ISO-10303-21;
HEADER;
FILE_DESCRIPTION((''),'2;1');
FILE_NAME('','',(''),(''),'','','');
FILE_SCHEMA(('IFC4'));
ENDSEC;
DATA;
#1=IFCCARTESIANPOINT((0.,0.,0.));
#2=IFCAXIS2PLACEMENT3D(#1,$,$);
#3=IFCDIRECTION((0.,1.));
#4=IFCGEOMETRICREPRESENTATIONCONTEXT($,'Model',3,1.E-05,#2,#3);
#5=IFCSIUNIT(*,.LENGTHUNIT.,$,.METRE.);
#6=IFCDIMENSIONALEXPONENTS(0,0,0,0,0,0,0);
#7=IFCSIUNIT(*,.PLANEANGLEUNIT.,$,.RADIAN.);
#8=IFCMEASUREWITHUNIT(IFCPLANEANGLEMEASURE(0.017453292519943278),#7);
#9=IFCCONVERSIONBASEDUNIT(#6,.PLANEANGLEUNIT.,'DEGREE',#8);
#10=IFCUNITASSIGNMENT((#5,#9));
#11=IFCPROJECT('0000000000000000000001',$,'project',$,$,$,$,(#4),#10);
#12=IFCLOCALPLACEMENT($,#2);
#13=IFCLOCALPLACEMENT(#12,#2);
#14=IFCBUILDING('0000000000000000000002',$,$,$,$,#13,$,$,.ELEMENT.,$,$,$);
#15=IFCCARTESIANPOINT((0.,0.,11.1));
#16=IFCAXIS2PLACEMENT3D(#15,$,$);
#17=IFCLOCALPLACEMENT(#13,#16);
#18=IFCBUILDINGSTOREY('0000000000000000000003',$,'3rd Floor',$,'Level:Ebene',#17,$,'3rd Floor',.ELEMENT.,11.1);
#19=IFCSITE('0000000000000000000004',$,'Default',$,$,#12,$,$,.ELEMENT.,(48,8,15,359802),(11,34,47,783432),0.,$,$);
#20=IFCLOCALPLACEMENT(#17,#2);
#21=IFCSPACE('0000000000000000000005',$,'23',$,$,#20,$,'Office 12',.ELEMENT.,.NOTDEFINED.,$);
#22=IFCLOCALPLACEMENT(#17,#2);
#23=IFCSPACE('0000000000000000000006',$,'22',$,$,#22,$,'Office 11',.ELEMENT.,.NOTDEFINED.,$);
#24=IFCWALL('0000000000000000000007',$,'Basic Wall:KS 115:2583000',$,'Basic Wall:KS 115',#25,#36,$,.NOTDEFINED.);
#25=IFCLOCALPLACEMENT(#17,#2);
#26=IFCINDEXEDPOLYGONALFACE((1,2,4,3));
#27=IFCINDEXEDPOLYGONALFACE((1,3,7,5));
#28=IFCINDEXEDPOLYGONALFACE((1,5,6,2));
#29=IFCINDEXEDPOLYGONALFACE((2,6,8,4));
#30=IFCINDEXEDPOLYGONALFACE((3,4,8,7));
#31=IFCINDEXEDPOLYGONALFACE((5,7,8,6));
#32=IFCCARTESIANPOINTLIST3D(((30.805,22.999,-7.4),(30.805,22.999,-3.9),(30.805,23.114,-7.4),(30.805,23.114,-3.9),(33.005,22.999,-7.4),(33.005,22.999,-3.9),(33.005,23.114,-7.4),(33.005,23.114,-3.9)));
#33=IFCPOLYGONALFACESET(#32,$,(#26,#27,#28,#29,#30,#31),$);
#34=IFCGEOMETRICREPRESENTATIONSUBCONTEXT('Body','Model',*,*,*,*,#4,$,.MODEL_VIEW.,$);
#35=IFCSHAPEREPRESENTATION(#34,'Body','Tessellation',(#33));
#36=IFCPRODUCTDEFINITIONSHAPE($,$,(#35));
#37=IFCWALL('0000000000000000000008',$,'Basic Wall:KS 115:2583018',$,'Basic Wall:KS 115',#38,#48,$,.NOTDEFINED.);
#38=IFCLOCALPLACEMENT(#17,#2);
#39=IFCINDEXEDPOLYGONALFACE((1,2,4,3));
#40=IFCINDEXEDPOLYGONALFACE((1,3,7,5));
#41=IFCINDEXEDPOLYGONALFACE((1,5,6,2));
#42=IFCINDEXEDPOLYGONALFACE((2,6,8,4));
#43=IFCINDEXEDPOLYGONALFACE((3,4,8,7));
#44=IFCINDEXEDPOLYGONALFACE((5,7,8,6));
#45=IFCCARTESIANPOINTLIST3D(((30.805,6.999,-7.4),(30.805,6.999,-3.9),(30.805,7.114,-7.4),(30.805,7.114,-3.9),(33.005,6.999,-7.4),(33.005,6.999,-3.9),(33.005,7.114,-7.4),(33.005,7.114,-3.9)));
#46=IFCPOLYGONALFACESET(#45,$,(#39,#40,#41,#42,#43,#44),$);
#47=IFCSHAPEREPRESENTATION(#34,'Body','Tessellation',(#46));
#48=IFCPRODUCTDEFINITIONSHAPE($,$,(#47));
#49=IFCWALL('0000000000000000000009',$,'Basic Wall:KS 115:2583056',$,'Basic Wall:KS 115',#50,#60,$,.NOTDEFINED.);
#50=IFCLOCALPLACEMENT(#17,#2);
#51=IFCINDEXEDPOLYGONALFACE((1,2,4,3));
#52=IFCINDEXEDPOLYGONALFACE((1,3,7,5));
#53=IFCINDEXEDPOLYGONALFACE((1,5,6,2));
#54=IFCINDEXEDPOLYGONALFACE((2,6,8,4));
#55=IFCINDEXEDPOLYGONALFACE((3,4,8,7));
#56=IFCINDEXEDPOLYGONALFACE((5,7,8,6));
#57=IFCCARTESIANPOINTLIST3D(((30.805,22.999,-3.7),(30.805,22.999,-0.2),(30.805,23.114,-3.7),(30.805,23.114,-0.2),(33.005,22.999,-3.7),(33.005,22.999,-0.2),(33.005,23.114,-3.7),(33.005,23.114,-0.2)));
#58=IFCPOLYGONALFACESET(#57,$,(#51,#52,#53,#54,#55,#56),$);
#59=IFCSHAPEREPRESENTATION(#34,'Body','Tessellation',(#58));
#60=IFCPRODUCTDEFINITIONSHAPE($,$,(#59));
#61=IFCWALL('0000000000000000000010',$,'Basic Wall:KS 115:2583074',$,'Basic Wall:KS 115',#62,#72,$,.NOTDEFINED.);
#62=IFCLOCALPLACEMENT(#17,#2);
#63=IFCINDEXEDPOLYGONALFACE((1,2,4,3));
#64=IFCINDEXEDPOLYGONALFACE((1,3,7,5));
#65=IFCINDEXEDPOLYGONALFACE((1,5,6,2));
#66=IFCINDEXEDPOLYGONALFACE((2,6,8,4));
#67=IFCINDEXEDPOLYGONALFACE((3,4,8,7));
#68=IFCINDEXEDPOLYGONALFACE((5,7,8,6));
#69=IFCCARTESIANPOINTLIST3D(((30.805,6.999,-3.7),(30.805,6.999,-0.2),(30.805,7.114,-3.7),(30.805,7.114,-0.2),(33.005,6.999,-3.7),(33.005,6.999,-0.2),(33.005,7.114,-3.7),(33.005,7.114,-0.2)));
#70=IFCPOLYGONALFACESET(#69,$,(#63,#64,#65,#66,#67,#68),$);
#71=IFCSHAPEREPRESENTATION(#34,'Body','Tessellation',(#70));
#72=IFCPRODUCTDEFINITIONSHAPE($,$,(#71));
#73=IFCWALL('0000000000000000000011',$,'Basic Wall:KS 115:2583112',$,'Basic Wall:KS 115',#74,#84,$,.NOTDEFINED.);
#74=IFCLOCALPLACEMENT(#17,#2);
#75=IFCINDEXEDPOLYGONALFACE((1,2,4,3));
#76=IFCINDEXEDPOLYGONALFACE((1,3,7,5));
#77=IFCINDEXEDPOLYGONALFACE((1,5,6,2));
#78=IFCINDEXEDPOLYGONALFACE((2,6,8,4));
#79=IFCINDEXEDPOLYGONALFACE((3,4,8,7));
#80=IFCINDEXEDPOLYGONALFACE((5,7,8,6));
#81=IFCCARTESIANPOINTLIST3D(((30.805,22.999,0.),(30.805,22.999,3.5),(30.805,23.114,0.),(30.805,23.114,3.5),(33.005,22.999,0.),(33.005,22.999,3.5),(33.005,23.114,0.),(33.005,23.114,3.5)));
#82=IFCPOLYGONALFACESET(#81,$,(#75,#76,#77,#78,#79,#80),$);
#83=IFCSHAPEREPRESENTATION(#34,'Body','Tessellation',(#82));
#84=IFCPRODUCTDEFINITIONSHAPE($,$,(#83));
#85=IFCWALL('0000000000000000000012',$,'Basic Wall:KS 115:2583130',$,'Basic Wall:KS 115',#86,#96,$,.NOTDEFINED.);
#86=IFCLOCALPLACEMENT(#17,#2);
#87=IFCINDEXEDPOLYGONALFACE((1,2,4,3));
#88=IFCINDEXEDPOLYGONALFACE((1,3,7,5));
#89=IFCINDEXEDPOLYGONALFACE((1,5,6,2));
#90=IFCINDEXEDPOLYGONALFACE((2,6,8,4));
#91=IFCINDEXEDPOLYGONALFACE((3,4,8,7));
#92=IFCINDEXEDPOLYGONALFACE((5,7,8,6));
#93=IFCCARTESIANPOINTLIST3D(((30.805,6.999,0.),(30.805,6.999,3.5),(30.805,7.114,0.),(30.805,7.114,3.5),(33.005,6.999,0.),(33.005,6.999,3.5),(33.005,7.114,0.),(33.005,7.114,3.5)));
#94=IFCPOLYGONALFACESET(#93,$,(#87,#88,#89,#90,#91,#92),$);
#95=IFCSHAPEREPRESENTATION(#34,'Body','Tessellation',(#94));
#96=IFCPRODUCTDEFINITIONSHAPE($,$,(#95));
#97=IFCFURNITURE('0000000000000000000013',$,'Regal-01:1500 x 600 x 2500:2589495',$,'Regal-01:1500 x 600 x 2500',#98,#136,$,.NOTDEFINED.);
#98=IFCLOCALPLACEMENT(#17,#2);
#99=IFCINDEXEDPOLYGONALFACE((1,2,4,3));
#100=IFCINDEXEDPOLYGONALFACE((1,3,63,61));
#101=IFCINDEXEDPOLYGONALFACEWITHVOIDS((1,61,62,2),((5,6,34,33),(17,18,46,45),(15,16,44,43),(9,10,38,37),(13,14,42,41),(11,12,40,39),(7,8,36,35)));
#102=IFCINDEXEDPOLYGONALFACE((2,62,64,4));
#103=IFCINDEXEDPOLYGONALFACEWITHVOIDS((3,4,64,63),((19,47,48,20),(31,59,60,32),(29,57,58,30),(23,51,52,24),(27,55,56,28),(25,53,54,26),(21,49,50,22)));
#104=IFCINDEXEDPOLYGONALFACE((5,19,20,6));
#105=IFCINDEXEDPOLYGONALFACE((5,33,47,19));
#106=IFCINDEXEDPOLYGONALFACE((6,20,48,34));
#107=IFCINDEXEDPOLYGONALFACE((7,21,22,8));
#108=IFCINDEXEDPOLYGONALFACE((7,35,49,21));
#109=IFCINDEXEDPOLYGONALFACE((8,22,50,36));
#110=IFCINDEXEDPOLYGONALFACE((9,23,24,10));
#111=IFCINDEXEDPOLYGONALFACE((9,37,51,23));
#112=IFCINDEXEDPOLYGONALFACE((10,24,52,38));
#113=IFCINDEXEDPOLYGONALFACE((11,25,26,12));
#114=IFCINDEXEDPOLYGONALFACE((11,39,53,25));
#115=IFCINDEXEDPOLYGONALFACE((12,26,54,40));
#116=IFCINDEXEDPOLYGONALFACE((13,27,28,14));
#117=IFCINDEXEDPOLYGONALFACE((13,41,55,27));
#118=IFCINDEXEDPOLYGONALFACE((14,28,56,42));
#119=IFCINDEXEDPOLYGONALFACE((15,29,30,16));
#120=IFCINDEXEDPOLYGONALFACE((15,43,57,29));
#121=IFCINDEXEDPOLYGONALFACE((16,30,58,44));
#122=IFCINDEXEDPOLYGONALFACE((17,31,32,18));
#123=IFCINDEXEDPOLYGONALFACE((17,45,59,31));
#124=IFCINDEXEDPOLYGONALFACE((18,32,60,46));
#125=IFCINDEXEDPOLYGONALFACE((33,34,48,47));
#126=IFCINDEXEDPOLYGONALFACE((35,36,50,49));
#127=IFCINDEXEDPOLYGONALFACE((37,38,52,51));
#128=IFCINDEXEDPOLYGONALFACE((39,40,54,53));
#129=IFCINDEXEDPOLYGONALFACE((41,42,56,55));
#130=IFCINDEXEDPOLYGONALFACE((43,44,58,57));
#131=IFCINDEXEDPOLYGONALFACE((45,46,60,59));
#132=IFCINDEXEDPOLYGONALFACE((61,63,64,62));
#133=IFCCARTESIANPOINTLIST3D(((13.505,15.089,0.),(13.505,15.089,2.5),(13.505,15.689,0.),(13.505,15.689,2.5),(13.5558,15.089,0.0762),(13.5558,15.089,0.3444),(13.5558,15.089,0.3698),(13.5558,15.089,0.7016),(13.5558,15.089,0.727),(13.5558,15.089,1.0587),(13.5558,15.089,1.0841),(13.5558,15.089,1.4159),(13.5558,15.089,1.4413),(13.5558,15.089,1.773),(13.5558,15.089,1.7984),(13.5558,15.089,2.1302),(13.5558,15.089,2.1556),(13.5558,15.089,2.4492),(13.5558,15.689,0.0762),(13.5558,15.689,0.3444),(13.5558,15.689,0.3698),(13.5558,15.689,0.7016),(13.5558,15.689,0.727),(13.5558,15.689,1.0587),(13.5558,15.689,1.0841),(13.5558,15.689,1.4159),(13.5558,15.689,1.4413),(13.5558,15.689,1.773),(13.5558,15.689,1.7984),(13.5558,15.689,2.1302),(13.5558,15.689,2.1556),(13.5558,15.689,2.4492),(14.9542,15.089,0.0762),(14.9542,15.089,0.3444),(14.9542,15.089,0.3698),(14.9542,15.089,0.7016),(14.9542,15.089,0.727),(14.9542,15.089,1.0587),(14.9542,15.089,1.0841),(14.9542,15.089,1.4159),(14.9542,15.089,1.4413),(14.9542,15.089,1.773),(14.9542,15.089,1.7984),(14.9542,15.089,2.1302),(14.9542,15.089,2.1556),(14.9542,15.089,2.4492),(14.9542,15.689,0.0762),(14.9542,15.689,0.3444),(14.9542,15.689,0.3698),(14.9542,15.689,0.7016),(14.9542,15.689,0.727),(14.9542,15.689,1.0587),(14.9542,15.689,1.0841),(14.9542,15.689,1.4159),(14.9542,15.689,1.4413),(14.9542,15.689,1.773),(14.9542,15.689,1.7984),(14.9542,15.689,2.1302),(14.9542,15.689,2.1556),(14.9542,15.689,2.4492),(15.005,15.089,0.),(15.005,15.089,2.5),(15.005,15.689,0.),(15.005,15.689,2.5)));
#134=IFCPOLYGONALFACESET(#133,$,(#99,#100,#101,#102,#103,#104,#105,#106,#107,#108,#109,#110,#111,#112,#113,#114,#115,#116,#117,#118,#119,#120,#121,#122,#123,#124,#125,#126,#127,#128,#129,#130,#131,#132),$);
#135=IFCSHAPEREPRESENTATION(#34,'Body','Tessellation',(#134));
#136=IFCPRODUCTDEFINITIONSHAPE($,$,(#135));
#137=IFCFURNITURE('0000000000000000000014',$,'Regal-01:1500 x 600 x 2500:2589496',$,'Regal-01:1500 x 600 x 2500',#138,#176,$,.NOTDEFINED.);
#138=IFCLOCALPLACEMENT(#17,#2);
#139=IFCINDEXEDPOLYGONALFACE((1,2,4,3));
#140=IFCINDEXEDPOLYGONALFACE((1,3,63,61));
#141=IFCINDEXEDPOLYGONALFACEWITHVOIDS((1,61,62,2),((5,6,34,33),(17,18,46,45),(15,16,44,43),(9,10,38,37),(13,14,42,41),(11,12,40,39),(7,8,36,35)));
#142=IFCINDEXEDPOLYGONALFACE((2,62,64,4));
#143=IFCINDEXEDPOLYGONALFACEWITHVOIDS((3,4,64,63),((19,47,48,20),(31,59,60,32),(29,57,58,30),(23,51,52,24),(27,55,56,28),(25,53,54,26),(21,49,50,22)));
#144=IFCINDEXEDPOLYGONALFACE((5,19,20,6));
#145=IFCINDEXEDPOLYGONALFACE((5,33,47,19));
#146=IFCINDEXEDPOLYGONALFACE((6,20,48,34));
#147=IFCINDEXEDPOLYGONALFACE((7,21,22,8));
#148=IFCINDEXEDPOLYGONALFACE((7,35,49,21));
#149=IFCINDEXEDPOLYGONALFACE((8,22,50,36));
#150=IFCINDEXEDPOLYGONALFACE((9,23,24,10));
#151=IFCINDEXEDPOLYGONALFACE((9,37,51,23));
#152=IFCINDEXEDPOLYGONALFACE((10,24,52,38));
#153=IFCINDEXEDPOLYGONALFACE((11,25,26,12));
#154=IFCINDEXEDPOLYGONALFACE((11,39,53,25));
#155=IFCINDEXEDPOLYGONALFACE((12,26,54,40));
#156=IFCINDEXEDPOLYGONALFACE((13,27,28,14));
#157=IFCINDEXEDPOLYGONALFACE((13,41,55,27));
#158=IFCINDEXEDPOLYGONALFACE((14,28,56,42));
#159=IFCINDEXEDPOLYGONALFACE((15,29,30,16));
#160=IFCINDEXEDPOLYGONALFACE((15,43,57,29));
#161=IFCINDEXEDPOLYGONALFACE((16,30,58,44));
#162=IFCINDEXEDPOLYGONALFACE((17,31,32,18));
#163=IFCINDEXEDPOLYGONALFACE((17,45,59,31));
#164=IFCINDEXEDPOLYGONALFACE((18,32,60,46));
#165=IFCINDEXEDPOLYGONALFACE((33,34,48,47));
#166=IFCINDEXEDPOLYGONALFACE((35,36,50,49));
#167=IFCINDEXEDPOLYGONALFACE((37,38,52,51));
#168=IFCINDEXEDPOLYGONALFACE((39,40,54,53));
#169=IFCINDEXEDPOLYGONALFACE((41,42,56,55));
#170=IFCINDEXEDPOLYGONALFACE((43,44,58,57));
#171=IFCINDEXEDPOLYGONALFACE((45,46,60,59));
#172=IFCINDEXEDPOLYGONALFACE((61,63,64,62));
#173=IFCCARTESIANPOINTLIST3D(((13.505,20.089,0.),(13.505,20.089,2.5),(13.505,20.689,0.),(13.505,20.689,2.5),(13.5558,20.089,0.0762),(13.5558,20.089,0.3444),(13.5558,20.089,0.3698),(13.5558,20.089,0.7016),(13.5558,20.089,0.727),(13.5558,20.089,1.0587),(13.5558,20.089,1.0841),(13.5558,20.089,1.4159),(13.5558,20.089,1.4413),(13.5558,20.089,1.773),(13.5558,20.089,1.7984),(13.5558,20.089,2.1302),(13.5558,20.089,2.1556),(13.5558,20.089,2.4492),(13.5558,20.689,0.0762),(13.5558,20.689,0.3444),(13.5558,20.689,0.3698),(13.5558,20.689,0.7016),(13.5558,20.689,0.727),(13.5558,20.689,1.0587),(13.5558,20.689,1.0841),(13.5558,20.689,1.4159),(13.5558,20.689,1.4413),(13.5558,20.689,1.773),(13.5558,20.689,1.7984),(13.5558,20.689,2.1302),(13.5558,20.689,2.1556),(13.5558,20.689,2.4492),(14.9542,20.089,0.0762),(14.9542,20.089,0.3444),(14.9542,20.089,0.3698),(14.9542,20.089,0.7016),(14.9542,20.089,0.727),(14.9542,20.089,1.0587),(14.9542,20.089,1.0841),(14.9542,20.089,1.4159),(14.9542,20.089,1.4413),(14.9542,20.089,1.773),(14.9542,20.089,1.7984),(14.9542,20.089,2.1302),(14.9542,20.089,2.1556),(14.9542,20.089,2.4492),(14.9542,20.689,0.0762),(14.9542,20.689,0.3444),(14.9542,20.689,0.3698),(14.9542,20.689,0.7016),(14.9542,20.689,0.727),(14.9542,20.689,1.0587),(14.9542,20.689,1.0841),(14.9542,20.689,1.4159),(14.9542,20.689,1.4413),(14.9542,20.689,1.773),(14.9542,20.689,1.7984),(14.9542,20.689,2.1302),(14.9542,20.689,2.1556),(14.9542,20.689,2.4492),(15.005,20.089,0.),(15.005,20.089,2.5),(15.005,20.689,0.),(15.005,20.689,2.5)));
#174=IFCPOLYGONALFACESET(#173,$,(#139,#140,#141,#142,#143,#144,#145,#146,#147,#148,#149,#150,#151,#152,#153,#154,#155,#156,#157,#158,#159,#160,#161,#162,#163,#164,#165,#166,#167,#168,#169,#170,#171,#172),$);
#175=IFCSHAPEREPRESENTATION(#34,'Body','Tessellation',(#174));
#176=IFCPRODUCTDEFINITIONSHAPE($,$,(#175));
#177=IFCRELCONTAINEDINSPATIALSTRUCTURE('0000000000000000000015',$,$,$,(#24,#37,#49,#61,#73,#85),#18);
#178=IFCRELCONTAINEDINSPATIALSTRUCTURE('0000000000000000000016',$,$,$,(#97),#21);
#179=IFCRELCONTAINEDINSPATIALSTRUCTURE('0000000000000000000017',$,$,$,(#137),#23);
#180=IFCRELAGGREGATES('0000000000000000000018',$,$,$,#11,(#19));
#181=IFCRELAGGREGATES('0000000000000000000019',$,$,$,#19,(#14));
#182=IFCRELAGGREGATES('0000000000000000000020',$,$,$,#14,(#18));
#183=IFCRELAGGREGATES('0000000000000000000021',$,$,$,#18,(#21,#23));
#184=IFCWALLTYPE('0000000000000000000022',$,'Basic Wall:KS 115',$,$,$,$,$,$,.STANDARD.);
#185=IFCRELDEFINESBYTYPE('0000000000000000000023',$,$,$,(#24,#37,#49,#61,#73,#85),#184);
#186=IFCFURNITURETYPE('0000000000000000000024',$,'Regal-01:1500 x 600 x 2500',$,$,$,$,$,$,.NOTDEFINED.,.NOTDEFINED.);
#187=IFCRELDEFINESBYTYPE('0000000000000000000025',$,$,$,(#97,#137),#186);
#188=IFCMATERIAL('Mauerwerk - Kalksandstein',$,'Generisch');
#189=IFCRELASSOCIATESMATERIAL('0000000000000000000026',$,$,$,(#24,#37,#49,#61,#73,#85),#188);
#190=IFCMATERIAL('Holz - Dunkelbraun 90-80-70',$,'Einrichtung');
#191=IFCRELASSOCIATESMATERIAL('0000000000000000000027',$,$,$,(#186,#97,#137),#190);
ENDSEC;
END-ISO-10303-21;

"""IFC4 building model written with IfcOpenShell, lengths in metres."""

from ifc_helpers import new_model, entity, si_unit, converted_unit, direction, frame, origin, place, context, subcontext, project, spatial, indexed_curve, outline, extrude, source, transform, mapped, material, type_object, type_shapes, element, save


model = new_model("IFC4")

# Units and contexts
model_context = context("Model", 3, precision=1e-05, world=origin(), true_north=direction((0.0, 1.0)))
body_context = subcontext(model_context, "Body", "Model", "MODEL_VIEW")
ifc_project = project(units=[si_unit("LENGTHUNIT", "METRE"), converted_unit("PLANEANGLEUNIT", "DEGREE", entity("IfcPlaneAngleMeasure", 0.017453292519943278), si_unit("PLANEANGLEUNIT", "RADIAN"), dimensions=[0, 0, 0, 0, 0, 0, 0])], contexts=[model_context])

# Site, building, storey
site_placement = place(None, origin())
site = spatial("IfcSite", under=ifc_project, at=site_placement, Name="Default", CompositionType="ELEMENT", RefLatitude=(48, 8, 15, 359802), RefLongitude=(11, 34, 47, 783432), RefElevation=0.0)
building_placement = place(site_placement, origin())
building = spatial("IfcBuilding", under=site, at=building_placement, CompositionType="ELEMENT")
storey_placement = place(building_placement, frame((0.0, 0.0, 11.1)))
storey = spatial("IfcBuildingStorey", under=building, at=storey_placement, Name="3rd Floor", ObjectType="Level:Ebene", LongName="3rd Floor", CompositionType="ELEMENT", Elevation=11.1)

# Walls
ifc_material_1 = material(Name="Mauerwerk - Kalksandstein", Category="Generisch")
wall_type_1 = type_object("IfcWallType", Name="Basic Wall:KS 115", PredefinedType="STANDARD")
wall_1_placement = place(storey_placement, frame((30.805, 23.0565, -7.4)))
element("IfcWall", 1, at=wall_1_placement, inside=storey, type_object=wall_type_1, material=ifc_material_1, Name="Basic Wall:KS 115:2583000", ObjectType="Basic Wall:KS 115", PredefinedType="NOTDEFINED", context=body_context, shape_type="SweptSolid", body=[
    extrude(outline(indexed_curve([(2.2, -0.0575), (2.2, 0.0575), (0.0, 0.0575), (0.0, -0.0575), (2.2, -0.0575)], self_intersect=False)), origin(), (0.0, 0.0, 1.0), 3.5),
])
wall_2_placement = place(storey_placement, frame((30.805, 7.0565, -7.4)))
element("IfcWall", 2, at=wall_2_placement, inside=storey, type_object=wall_type_1, material=ifc_material_1, Name="Basic Wall:KS 115:2583018", ObjectType="Basic Wall:KS 115", PredefinedType="NOTDEFINED", context=body_context, shape_type="SweptSolid", body=[
    extrude(outline(indexed_curve([(2.2, -0.0575), (2.2, 0.0575), (0.0, 0.0575), (0.0, -0.0575), (2.2, -0.0575)], self_intersect=False)), origin(), (0.0, 0.0, 1.0), 3.5),
])
wall_3_placement = place(storey_placement, frame((30.805, 23.0565, -3.7)))
element("IfcWall", 3, at=wall_3_placement, inside=storey, type_object=wall_type_1, material=ifc_material_1, Name="Basic Wall:KS 115:2583056", ObjectType="Basic Wall:KS 115", PredefinedType="NOTDEFINED", context=body_context, shape_type="SweptSolid", body=[
    extrude(outline(indexed_curve([(2.2, -0.0575), (2.2, 0.0575), (0.0, 0.0575), (0.0, -0.0575), (2.2, -0.0575)], self_intersect=False)), origin(), (0.0, 0.0, 1.0), 3.5),
])
wall_4_placement = place(storey_placement, frame((30.805, 7.0565, -3.7)))
element("IfcWall", 4, at=wall_4_placement, inside=storey, type_object=wall_type_1, material=ifc_material_1, Name="Basic Wall:KS 115:2583074", ObjectType="Basic Wall:KS 115", PredefinedType="NOTDEFINED", context=body_context, shape_type="SweptSolid", body=[
    extrude(outline(indexed_curve([(2.2, -0.0575), (2.2, 0.0575), (0.0, 0.0575), (0.0, -0.0575), (2.2, -0.0575)], self_intersect=False)), origin(), (0.0, 0.0, 1.0), 3.5),
])
wall_5_placement = place(storey_placement, frame((30.805, 23.0565, 0.0)))
element("IfcWall", 5, at=wall_5_placement, inside=storey, type_object=wall_type_1, material=ifc_material_1, Name="Basic Wall:KS 115:2583112", ObjectType="Basic Wall:KS 115", PredefinedType="NOTDEFINED", context=body_context, shape_type="SweptSolid", body=[
    extrude(outline(indexed_curve([(2.2, -0.0575), (2.2, 0.0575), (0.0, 0.0575), (0.0, -0.0575), (2.2, -0.0575)], self_intersect=False)), origin(), (0.0, 0.0, 1.0), 3.5),
])
wall_6_placement = place(storey_placement, frame((30.805, 7.0565, 0.0)))
element("IfcWall", 6, at=wall_6_placement, inside=storey, type_object=wall_type_1, material=ifc_material_1, Name="Basic Wall:KS 115:2583130", ObjectType="Basic Wall:KS 115", PredefinedType="NOTDEFINED", context=body_context, shape_type="SweptSolid", body=[
    extrude(outline(indexed_curve([(2.2, -0.0575), (2.2, 0.0575), (0.0, 0.0575), (0.0, -0.0575), (2.2, -0.0575)], self_intersect=False)), origin(), (0.0, 0.0, 1.0), 3.5),
])

# Shared definitions
space_1_placement = place(storey_placement, origin())
space_1 = spatial("IfcSpace", under=storey, at=space_1_placement, Name="23", LongName="Office 12", CompositionType="ELEMENT", PredefinedType="NOTDEFINED")

# Furniture
ifc_material_2 = material(Name="Holz - Dunkelbraun 90-80-70", Category="Einrichtung")
furniture_type = type_object("IfcFurnitureType", Name="Regal-01:1500 x 600 x 2500", AssemblyPlace="NOTDEFINED", PredefinedType="NOTDEFINED", material=ifc_material_2)
shared_shape = source(origin(), body_context, "Body", "SweptSolid", [
    extrude(outline(indexed_curve([(-0.75, -1.25), (0.75, -1.25), (0.75, 1.25), (-0.75, 1.25), (-0.75, -1.25)], self_intersect=False), holes=[indexed_curve([(-0.6992, 1.1992), (0.6992, 1.1992), (0.6992, 0.9056), (-0.6992, 0.9056), (-0.6992, 1.1992)], self_intersect=False), indexed_curve([(-0.6992, -1.1738), (-0.6992, -0.9056), (0.6992, -0.9056), (0.6992, -1.1738), (-0.6992, -1.1738)], self_intersect=False), indexed_curve([(0.6992, 0.1913), (-0.6992, 0.1913), (-0.6992, 0.523), (0.6992, 0.523), (0.6992, 0.1913)], self_intersect=False), indexed_curve([(0.6992, -0.5484), (0.6992, -0.8802), (-0.6992, -0.8802), (-0.6992, -0.5484), (0.6992, -0.5484)], self_intersect=False), indexed_curve([(-0.6992, 0.8802), (0.6992, 0.8802), (0.6992, 0.5484), (-0.6992, 0.5484), (-0.6992, 0.8802)], self_intersect=False), indexed_curve([(-0.6992, 0.1659), (0.6992, 0.1659), (0.6992, -0.1659), (-0.6992, -0.1659), (-0.6992, 0.1659)], self_intersect=False), indexed_curve([(-0.6992, -0.1913), (0.6992, -0.1913), (0.6992, -0.523), (-0.6992, -0.523), (-0.6992, -0.1913)], self_intersect=False)]), frame((0.0, -0.6048, 1.25), z_axis=(0.0, 1.0, 0.0), x_axis=(-1.0, 0.0, 0.0)), (0.0, 0.0, 1.0), 0.6),
])
type_shapes(furniture_type, [shared_shape])
furniture_1_placement = place(space_1_placement, frame((14.255, 15.6938, 0.0)))
element("IfcFurniture", 7, at=furniture_1_placement, inside=space_1, type_object=furniture_type, material=ifc_material_2, Name="Regal-01:1500 x 600 x 2500:2589495", ObjectType="Regal-01:1500 x 600 x 2500", PredefinedType="NOTDEFINED", context=body_context, shape_type="MappedRepresentation", body=[
    mapped(shared_shape, transform((0.0, 0.0, 0.0), scale=1.0)),
])

# Shared definitions
space_2_placement = place(storey_placement, origin())
space_2 = spatial("IfcSpace", under=storey, at=space_2_placement, Name="22", LongName="Office 11", CompositionType="ELEMENT", PredefinedType="NOTDEFINED")

# Furniture
furniture_2_placement = place(space_2_placement, frame((14.255, 20.6938, 0.0)))
element("IfcFurniture", 8, at=furniture_2_placement, inside=space_2, type_object=furniture_type, material=ifc_material_2, Name="Regal-01:1500 x 600 x 2500:2589496", ObjectType="Regal-01:1500 x 600 x 2500", PredefinedType="NOTDEFINED", context=body_context, shape_type="MappedRepresentation", body=[
    mapped(shared_shape, transform((0.0, 0.0, 0.0), scale=1.0)),
])

save(model, "model.ifc")
